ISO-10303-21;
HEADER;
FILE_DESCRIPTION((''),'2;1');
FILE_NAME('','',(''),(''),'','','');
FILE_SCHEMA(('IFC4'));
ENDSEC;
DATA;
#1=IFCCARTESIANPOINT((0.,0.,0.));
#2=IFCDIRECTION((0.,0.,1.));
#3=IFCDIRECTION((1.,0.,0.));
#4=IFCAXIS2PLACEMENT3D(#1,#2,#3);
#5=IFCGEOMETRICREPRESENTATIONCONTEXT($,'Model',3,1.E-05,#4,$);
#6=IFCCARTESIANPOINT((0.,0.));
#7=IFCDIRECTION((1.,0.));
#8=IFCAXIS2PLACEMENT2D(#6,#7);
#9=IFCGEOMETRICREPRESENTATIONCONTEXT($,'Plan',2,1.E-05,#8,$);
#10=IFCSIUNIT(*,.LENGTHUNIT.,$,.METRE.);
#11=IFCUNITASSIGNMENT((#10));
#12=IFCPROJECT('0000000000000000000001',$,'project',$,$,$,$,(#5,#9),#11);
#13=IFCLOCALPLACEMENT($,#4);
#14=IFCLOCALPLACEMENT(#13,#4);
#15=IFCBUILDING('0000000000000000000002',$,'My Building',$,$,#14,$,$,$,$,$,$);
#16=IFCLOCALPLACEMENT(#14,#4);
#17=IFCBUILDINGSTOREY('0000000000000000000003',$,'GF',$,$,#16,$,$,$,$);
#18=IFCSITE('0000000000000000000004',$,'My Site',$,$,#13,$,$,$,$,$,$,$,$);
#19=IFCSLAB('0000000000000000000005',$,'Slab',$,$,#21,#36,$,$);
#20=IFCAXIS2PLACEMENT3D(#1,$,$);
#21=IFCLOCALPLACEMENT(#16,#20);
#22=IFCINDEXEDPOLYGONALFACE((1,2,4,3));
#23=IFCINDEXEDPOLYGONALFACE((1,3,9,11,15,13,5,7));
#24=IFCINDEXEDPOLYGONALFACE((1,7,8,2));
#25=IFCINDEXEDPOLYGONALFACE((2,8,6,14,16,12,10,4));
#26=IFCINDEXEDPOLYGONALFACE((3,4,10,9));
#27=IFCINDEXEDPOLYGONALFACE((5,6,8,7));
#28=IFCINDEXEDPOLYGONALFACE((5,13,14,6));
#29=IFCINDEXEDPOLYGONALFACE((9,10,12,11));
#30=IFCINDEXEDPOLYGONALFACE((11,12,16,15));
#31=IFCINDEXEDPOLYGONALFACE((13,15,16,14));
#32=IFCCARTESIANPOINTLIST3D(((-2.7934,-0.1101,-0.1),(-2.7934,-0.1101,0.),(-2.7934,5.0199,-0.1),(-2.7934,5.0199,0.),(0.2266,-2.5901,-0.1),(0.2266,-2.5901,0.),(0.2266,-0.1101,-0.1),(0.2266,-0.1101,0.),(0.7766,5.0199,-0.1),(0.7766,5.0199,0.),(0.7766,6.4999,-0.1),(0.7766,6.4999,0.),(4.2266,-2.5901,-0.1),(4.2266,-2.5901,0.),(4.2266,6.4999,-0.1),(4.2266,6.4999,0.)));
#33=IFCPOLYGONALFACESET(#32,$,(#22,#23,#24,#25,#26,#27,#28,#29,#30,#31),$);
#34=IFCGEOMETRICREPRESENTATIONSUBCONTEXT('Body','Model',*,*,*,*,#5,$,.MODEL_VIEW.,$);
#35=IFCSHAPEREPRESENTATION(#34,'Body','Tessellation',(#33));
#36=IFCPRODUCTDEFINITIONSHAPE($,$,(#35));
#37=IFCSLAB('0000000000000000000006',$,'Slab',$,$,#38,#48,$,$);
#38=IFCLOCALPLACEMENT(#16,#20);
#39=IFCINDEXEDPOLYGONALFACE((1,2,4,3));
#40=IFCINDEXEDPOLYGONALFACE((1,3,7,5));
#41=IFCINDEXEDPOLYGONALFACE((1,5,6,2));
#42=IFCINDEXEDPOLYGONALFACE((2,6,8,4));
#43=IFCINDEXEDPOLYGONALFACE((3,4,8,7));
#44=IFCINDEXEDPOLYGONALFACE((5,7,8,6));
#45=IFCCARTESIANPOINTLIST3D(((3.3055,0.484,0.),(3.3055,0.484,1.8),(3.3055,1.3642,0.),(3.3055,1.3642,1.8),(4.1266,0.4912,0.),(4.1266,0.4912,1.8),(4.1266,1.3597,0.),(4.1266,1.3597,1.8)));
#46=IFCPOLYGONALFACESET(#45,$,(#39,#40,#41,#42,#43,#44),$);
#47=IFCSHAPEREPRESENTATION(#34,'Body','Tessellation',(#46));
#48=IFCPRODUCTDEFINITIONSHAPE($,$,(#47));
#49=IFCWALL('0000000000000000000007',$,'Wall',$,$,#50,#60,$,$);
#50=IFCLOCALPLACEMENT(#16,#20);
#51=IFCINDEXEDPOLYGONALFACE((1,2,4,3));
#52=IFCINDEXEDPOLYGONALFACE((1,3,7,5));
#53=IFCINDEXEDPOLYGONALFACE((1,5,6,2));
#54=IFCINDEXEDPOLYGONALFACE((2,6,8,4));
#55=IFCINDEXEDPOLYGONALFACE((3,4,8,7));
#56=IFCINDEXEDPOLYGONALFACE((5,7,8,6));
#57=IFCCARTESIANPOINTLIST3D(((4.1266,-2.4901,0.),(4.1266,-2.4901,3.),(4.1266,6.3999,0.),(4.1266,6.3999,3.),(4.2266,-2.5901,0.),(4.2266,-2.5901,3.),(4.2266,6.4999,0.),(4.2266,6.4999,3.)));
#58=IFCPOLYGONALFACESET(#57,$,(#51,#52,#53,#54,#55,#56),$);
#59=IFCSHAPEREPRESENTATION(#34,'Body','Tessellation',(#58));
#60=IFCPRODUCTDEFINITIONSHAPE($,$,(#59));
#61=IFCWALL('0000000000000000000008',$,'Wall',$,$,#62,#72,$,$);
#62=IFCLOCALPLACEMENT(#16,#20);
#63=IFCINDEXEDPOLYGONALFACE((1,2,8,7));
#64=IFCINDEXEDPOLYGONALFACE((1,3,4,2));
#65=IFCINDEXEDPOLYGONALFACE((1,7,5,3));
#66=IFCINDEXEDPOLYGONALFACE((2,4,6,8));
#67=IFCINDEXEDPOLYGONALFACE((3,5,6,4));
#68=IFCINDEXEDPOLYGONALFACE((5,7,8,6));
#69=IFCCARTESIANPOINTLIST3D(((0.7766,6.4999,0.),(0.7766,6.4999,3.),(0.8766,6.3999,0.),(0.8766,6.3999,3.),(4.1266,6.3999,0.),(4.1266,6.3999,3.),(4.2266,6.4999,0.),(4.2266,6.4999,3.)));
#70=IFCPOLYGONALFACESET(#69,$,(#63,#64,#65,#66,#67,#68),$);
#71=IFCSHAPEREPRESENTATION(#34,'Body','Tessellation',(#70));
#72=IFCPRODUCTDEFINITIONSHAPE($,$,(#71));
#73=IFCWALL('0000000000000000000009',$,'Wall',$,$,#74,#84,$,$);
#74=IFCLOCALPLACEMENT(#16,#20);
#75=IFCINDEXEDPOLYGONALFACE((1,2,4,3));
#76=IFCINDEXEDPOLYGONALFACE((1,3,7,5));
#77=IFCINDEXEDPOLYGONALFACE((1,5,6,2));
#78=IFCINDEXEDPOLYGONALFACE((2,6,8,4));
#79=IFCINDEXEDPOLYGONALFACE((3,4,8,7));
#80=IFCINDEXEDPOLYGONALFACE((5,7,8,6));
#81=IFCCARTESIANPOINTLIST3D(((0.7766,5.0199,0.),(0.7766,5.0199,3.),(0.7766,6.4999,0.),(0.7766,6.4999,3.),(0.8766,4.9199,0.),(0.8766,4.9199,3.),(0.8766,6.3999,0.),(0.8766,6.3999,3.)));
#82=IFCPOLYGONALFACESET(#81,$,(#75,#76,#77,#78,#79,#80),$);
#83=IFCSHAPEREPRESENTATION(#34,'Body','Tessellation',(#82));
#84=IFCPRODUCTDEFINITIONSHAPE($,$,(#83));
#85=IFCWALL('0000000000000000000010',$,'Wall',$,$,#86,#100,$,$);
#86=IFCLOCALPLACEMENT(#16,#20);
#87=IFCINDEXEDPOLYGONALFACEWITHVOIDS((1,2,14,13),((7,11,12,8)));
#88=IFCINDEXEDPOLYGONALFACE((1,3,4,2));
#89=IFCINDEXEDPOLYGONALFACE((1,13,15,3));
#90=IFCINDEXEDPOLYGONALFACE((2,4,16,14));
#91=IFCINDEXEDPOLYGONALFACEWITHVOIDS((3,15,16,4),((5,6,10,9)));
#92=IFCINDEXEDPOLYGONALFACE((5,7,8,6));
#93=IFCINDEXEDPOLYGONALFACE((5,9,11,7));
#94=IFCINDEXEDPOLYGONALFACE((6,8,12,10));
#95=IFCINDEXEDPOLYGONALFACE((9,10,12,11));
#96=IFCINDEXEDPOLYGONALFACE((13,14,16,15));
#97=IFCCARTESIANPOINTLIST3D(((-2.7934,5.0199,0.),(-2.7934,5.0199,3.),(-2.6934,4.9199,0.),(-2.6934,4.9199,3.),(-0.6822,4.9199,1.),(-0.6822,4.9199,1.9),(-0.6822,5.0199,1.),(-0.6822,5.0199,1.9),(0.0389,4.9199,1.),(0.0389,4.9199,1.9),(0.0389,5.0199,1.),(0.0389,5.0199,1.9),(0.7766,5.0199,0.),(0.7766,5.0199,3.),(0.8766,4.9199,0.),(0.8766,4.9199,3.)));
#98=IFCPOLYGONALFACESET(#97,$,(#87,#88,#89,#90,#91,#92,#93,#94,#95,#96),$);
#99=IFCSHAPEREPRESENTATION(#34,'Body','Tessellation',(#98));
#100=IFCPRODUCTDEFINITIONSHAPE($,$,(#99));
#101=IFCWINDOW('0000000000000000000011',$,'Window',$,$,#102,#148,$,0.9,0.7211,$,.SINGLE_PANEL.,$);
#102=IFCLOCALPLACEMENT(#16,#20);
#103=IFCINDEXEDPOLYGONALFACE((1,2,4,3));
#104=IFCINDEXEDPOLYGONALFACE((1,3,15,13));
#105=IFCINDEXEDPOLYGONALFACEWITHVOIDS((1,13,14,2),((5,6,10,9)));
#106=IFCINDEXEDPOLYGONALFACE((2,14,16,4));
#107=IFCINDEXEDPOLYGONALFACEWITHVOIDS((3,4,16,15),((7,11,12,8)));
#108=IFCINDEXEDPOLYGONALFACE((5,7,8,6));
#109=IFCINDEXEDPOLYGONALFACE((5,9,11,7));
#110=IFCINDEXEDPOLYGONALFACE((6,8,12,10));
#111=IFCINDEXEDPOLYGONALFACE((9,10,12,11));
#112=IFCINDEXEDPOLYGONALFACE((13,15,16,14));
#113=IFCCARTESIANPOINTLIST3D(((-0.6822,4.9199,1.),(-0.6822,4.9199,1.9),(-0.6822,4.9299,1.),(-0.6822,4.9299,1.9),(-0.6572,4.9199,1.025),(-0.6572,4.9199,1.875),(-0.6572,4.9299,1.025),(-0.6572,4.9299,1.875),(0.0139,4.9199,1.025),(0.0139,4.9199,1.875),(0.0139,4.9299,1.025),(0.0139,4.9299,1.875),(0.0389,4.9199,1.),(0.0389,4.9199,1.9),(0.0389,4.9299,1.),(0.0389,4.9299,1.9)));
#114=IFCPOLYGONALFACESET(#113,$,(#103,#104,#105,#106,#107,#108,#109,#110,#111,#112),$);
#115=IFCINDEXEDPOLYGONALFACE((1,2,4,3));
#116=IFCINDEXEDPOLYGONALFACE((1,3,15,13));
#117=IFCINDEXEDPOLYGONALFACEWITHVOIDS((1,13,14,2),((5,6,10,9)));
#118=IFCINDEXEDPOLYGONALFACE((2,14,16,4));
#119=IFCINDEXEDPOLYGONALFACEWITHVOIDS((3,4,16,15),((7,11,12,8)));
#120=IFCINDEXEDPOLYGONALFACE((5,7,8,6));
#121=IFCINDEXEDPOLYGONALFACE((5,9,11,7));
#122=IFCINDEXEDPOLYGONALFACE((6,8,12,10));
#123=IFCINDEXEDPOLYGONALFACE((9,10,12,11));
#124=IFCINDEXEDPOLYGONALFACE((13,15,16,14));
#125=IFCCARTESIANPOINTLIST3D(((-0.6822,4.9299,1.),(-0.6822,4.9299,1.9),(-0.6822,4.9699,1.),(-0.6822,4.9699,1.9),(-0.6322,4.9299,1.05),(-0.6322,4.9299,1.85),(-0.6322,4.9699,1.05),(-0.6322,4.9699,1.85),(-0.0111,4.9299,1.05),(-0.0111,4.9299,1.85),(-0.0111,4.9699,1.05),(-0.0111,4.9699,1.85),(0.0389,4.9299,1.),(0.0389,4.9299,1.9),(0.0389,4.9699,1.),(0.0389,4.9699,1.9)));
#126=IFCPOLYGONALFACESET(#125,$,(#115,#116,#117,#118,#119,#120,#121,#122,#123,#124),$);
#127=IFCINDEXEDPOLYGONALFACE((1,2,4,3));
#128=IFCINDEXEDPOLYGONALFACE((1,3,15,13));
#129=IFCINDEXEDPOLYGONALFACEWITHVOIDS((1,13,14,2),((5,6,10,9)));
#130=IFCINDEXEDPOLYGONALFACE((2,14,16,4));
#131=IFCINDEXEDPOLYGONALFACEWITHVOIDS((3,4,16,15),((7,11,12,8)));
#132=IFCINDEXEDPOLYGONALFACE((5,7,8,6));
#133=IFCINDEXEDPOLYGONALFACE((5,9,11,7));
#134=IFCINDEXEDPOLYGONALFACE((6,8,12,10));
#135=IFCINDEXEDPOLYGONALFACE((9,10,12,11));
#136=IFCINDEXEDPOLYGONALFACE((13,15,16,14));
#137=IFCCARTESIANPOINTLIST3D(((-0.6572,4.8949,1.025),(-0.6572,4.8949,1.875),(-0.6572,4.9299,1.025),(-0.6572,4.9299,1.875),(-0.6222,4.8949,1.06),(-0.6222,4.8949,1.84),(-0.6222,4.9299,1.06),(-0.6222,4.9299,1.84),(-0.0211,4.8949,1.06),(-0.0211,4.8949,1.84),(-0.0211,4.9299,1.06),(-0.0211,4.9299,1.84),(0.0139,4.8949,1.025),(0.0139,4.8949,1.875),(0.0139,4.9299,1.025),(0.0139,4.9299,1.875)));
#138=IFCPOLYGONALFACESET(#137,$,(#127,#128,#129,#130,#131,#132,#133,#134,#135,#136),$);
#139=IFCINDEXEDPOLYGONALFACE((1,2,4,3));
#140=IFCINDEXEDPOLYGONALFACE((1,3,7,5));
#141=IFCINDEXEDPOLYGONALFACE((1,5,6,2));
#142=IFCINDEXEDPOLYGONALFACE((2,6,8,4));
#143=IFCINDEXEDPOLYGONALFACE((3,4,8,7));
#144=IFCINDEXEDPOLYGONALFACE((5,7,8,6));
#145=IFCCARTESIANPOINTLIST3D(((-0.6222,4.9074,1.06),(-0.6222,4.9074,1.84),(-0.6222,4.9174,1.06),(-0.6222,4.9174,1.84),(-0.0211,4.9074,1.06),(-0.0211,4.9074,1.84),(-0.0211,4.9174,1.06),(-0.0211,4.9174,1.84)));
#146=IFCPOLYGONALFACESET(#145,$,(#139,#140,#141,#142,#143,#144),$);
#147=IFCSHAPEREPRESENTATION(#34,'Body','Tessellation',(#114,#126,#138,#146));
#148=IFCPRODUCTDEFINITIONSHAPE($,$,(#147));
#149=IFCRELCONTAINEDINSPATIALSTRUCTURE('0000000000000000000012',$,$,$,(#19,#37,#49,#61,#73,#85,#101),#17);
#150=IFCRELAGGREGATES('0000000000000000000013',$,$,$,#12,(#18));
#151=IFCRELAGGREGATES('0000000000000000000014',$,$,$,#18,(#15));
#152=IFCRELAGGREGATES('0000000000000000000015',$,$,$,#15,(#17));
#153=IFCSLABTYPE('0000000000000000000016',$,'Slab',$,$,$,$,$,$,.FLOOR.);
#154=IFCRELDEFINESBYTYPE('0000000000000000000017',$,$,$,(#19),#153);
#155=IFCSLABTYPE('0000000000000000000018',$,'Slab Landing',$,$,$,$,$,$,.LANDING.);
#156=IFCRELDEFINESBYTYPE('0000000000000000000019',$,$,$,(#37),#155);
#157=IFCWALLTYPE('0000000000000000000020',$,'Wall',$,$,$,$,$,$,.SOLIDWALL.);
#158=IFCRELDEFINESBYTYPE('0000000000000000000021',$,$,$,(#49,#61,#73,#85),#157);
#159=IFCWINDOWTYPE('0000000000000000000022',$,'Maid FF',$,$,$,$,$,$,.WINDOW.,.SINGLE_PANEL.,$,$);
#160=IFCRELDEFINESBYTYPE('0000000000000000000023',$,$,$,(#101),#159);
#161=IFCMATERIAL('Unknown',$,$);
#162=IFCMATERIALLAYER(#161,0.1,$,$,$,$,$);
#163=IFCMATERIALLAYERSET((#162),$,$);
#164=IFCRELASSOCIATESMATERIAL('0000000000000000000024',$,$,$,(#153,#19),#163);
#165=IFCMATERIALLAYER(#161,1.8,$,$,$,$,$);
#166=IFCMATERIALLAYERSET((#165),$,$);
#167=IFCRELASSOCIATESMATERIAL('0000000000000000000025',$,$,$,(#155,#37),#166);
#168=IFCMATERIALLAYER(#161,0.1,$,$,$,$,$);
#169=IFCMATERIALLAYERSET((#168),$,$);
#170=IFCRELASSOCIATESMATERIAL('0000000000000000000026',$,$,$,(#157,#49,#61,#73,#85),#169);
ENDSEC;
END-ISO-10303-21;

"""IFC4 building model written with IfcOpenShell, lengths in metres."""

from ifc_helpers import new_model, entity, si_unit, frame, origin_with_axes, origin_2d_with_axis, place, context, subcontext, project, spatial, line, indexed_curve, outline, extrude, shape, source, transform, mapped, material, layer, layer_set, layer_usage, type_object, type_shapes, element, fill, save


model = new_model("IFC4")

# Units and contexts
model_context = context("Model", 3, precision=1e-05, world=origin_with_axes())
plan_context = context("Plan", 2, precision=1e-05, world=origin_2d_with_axis())
body_context_1 = subcontext(model_context, "Body", "Model", "MODEL_VIEW")
body_context_2 = subcontext(plan_context, "Body", "Plan", "PLAN_VIEW")
ifc_project = project(units=[si_unit("LENGTHUNIT", "METRE")], contexts=[model_context, plan_context])

# Site, building, storey
site_placement = place(None, origin_with_axes())
site = spatial("IfcSite", under=ifc_project, at=site_placement, Name="My Site")
building_placement = place(site_placement, origin_with_axes())
building = spatial("IfcBuilding", under=site, at=building_placement, Name="My Building")
storey_placement = place(building_placement, origin_with_axes())
storey = spatial("IfcBuildingStorey", under=building, at=storey_placement, Name="GF")

# Slabs
ifc_material = material(Name="Unknown")
ifc_layer_1 = layer(ifc_material, 0.1)
ifc_layer_set_1 = layer_set([ifc_layer_1])
ifc_layer_usage_1 = layer_usage(ifc_layer_set_1, "AXIS3", "POSITIVE", -0.1)
slab_type_1 = type_object("IfcSlabType", Name="Slab", PredefinedType="FLOOR", material=ifc_layer_set_1)
slab_1_placement = place(storey_placement, frame((4.2266, -2.5901, 0.0), z_axis=(0.0, 0.0, 1.0), x_axis=(1.0, 0.0, 0.0)))
element("IfcSlab", 1, at=slab_1_placement, inside=storey, type_object=slab_type_1, material=ifc_layer_usage_1, Name="Slab", context=body_context_1, shape_type="SweptSolid", body=[
    extrude(outline(indexed_curve([(0.0, 0.0), (0.0, 9.09), (-3.45, 9.09), (-3.45, 7.61), (-7.02, 7.61), (-7.02, 2.48), (-4.0, 2.48), (-4.0, 0.0), (0.0, 0.0)])), frame((0.0, 0.0, -0.1), z_axis=(0.0, 0.0, 1.0), x_axis=(1.0, 0.0, 0.0)), (0.0, 0.0, 1.0), 0.1),
])
ifc_layer_2 = layer(ifc_material, 1.8)
ifc_layer_set_2 = layer_set([ifc_layer_2])
ifc_layer_usage_2 = layer_usage(ifc_layer_set_2, "AXIS3", "POSITIVE", -0.1)
slab_type_2 = type_object("IfcSlabType", Name="Slab Landing", PredefinedType="LANDING", material=ifc_layer_set_2)
slab_2_placement = place(storey_placement, frame((3.3055, 1.3642, 0.1), z_axis=(0.0, 0.0, 1.0), x_axis=(1.0, 0.0, 0.0)))
element("IfcSlab", 2, at=slab_2_placement, inside=storey, type_object=slab_type_2, material=ifc_layer_usage_2, Name="Slab", context=body_context_1, shape_type="SweptSolid", body=[
    extrude(outline(indexed_curve([(0.0, -0.8801), (0.8211, -0.8729), (0.8211, -0.0045), (0.0, 0.0), (0.0, -0.8801)])), frame((0.0, 0.0, -0.1), z_axis=(0.0, 0.0, 1.0), x_axis=(1.0, 0.0, 0.0)), (0.0, 0.0, 1.0), 1.8),
])

# Shared definitions
ifc_layer_3 = layer(ifc_material, 0.1)
ifc_layer_set_3 = layer_set([ifc_layer_3])
wall_type = type_object("IfcWallType", Name="Wall", PredefinedType="SOLIDWALL", material=ifc_layer_set_3)

# Walls
ifc_layer_usage_3 = layer_usage(ifc_layer_set_3, "AXIS2", "POSITIVE", 0.0)
wall_1_placement = place(storey_placement, frame((4.2266, -2.5901, 0.0), z_axis=(0.0, 0.0, 1.0), x_axis=(0.0, 1.0, 0.0)))
element("IfcWall", 3, at=wall_1_placement, inside=storey, type_object=wall_type, material=ifc_layer_usage_3, Name="Wall", context=body_context_1, shape_type="SweptSolid", body=[
    extrude(outline(indexed_curve([(0.0, 0.0), (0.1, 0.1), (8.99, 0.1), (9.09, 0.0)], segments=[line(1, 2, 3, 4, 1)])), origin_with_axes(), (0.0, 0.0, 1.0), 3.0),
])
ifc_layer_usage_4 = layer_usage(ifc_layer_set_3, "AXIS2", "POSITIVE", 0.0)
wall_2_placement = place(storey_placement, frame((4.2266, 6.4999, 0.0), z_axis=(0.0, 0.0, 1.0), x_axis=(-1.0, 0.0, 0.0)))
element("IfcWall", 4, at=wall_2_placement, inside=storey, type_object=wall_type, material=ifc_layer_usage_4, Name="Wall", context=body_context_1, shape_type="SweptSolid", body=[
    extrude(outline(indexed_curve([(0.0, 0.0), (0.1, 0.1), (3.35, 0.1), (3.45, 0.0)], segments=[line(1, 2, 3, 4, 1)])), origin_with_axes(), (0.0, 0.0, 1.0), 3.0),
])
ifc_layer_usage_5 = layer_usage(ifc_layer_set_3, "AXIS2", "POSITIVE", 0.0)
wall_3_placement = place(storey_placement, frame((0.7766, 6.4999, 0.0), z_axis=(0.0, 0.0, 1.0), x_axis=(0.0, -1.0, 0.0)))
element("IfcWall", 5, at=wall_3_placement, inside=storey, type_object=wall_type, material=ifc_layer_usage_5, Name="Wall", context=body_context_1, shape_type="SweptSolid", body=[
    extrude(outline(indexed_curve([(0.0, 0.0), (0.1, 0.1), (1.58, 0.1), (1.48, 0.0)], segments=[line(1, 2, 3, 4, 1)])), origin_with_axes(), (0.0, 0.0, 1.0), 3.0),
])

# Wall, opening, window
ifc_layer_usage_6 = layer_usage(ifc_layer_set_3, "AXIS2", "POSITIVE", 0.0)
wall_4_placement = place(storey_placement, frame((0.7766, 5.0199, 0.0), z_axis=(0.0, 0.0, 1.0), x_axis=(-1.0, 0.0, 0.0)))
wall_4 = element("IfcWall", 6, at=wall_4_placement, inside=storey, type_object=wall_type, material=ifc_layer_usage_6, Name="Wall", context=body_context_1, shape_type="SweptSolid", body=[
    extrude(outline(indexed_curve([(0.0, 0.0), (-0.1, 0.1), (3.47, 0.1), (3.57, 0.0)], segments=[line(1, 2, 3, 4, 1)])), origin_with_axes(), (0.0, 0.0, 1.0), 3.0),
])
shared_shape_1 = source(origin_with_axes(), body_context_1, "Body", "SweptSolid", [
    extrude(outline(indexed_curve([(0.0, 0.0), (0.7211, 0.0), (0.7211, 0.9), (0.0, 0.9)], segments=[line(1, 2, 3, 4, 1)])), frame((0.0, -0.6, 0.0), z_axis=(0.0, -1.0, 0.0), x_axis=(1.0, 0.0, 0.0)), (0.0, 0.0, -1.0), 1.2),
])
opening_1_placement = place(wall_4_placement, frame((0.7377, 0.0, 1.0), z_axis=(0.0, 0.0, 1.0), x_axis=(1.0, 0.0, 0.0)))
opening_1 = element("IfcOpeningElement", 7, at=opening_1_placement, cuts=wall_4, PredefinedType="OPENING", context=body_context_1, shape_type="MappedRepresentation", body=[
    mapped(shared_shape_1, transform((0.0, 0.0, 0.0), x_axis=(1.0, 0.0, 0.0), y_axis=(0.0, 1.0, 0.0), z_axis=(0.0, 0.0, 1.0), scale=1.0)),
])
window_type_1 = type_object("IfcWindowType", Name="Maid FF", PartitioningType="SINGLE_PANEL", PredefinedType="WINDOW")
shared_shape_2 = source(origin_with_axes(), body_context_1, "Body", "SweptSolid", [
    extrude(outline(indexed_curve([(0.0, 0.0), (0.7211, 0.0), (0.7211, 0.9), (0.0, 0.9)], segments=[line(1, 2, 3, 4, 1)]), holes=[indexed_curve([(0.025, 0.025), (0.6961, 0.025), (0.6961, 0.875), (0.025, 0.875)], segments=[line(1, 2, 3, 4, 1)])]), frame((0.0, 0.09, 0.0), z_axis=(0.0, -1.0, 0.0), x_axis=(1.0, 0.0, 0.0)), (0.0, 0.0, -1.0), 0.01),
    extrude(outline(indexed_curve([(0.0, 0.0), (0.7211, 0.0), (0.7211, 0.9), (0.0, 0.9)], segments=[line(1, 2, 3, 4, 1)]), holes=[indexed_curve([(0.05, 0.05), (0.6711, 0.05), (0.6711, 0.85), (0.05, 0.85)], segments=[line(1, 2, 3, 4, 1)])]), frame((0.0, 0.05, 0.0), z_axis=(0.0, -1.0, 0.0), x_axis=(1.0, 0.0, 0.0)), (0.0, 0.0, -1.0), 0.04),
    extrude(outline(indexed_curve([(0.0, 0.0), (0.6711, 0.0), (0.6711, 0.85), (0.0, 0.85)], segments=[line(1, 2, 3, 4, 1)]), holes=[indexed_curve([(0.035, 0.035), (0.6361, 0.035), (0.6361, 0.815), (0.035, 0.815)], segments=[line(1, 2, 3, 4, 1)])]), frame((0.025, 0.09, 0.025), z_axis=(0.0, -1.0, 0.0), x_axis=(1.0, 0.0, 0.0)), (0.0, 0.0, -1.0), 0.035),
    extrude(outline(indexed_curve([(0.035, 0.035), (0.6361, 0.035), (0.6361, 0.815), (0.035, 0.815)], segments=[line(1, 2, 3, 4, 1)])), frame((0.025, 0.1025, 0.025), z_axis=(0.0, -1.0, 0.0), x_axis=(1.0, 0.0, 0.0)), (0.0, 0.0, -1.0), 0.01),
])
shared_shape_3 = source(origin_with_axes(), body_context_2, "Body", "Curve2D", [
    entity("IfcIndexedPolyCurve", entity("IfcCartesianPointList2D", [[0.05, 0.05], [0.6711, 0.05]])),
    entity("IfcIndexedPolyCurve", entity("IfcCartesianPointList2D", [[0.0, 0.1], [0.025, 0.1], [0.025, 0.09], [0.05, 0.09], [0.05, 0.05], [0.0, 0.05]]), [entity("IfcLineIndex", [1, 2, 3, 4, 5, 6, 1])]),
    entity("IfcIndexedPolyCurve", entity("IfcCartesianPointList2D", [[0.7211, 0.1], [0.6961, 0.1], [0.6961, 0.09], [0.6711, 0.09], [0.6711, 0.05], [0.7211, 0.05]]), [entity("IfcLineIndex", [1, 2, 3, 4, 5, 6, 1])]),
    entity("IfcIndexedPolyCurve", entity("IfcCartesianPointList2D", [[0.025, 0.09], [0.06, 0.09], [0.06, 0.125], [0.025, 0.125]]), [entity("IfcLineIndex", [1, 2, 3, 4, 1])]),
    entity("IfcIndexedPolyCurve", entity("IfcCartesianPointList2D", [[0.6961, 0.09], [0.6611, 0.09], [0.6611, 0.125], [0.6961, 0.125]]), [entity("IfcLineIndex", [1, 2, 3, 4, 1])]),
    entity("IfcIndexedPolyCurve", entity("IfcCartesianPointList2D", [[0.06, 0.09], [0.6611, 0.09]])),
    entity("IfcIndexedPolyCurve", entity("IfcCartesianPointList2D", [[0.06, 0.125], [0.6611, 0.125]])),
    entity("IfcIndexedPolyCurve", entity("IfcCartesianPointList2D", [[0.06, 0.1075], [0.6611, 0.1075]])),
])
type_shapes(window_type_1, [shared_shape_2, shared_shape_3])
window_1_placement = place(opening_1_placement, frame((0.0, 0.0, 0.0), z_axis=(0.0, 0.0, 1.0), x_axis=(1.0, 0.0, 0.0)))
window_1 = element("IfcWindow", 8, at=window_1_placement, inside=storey, type_object=window_type_1, Name="Window", OverallHeight=0.9, OverallWidth=0.7211, PartitioningType="SINGLE_PANEL", shapes=[
    shape(body_context_1, "Body", "MappedRepresentation", [mapped(shared_shape_2, transform((0.0, 0.0, 0.0), x_axis=(1.0, 0.0, 0.0), y_axis=(0.0, 1.0, 0.0), z_axis=(0.0, 0.0, 1.0), scale=1.0))]),
    shape(body_context_2, "Body", "MappedRepresentation", [mapped(shared_shape_3, transform((0.0, 0.0, 0.0), x_axis=(1.0, 0.0, 0.0), y_axis=(0.0, 1.0, 0.0), z_axis=(0.0, 0.0, 1.0), scale=1.0))]),
])
fill(opening_1, window_1)

save(model, "model.ifc")
